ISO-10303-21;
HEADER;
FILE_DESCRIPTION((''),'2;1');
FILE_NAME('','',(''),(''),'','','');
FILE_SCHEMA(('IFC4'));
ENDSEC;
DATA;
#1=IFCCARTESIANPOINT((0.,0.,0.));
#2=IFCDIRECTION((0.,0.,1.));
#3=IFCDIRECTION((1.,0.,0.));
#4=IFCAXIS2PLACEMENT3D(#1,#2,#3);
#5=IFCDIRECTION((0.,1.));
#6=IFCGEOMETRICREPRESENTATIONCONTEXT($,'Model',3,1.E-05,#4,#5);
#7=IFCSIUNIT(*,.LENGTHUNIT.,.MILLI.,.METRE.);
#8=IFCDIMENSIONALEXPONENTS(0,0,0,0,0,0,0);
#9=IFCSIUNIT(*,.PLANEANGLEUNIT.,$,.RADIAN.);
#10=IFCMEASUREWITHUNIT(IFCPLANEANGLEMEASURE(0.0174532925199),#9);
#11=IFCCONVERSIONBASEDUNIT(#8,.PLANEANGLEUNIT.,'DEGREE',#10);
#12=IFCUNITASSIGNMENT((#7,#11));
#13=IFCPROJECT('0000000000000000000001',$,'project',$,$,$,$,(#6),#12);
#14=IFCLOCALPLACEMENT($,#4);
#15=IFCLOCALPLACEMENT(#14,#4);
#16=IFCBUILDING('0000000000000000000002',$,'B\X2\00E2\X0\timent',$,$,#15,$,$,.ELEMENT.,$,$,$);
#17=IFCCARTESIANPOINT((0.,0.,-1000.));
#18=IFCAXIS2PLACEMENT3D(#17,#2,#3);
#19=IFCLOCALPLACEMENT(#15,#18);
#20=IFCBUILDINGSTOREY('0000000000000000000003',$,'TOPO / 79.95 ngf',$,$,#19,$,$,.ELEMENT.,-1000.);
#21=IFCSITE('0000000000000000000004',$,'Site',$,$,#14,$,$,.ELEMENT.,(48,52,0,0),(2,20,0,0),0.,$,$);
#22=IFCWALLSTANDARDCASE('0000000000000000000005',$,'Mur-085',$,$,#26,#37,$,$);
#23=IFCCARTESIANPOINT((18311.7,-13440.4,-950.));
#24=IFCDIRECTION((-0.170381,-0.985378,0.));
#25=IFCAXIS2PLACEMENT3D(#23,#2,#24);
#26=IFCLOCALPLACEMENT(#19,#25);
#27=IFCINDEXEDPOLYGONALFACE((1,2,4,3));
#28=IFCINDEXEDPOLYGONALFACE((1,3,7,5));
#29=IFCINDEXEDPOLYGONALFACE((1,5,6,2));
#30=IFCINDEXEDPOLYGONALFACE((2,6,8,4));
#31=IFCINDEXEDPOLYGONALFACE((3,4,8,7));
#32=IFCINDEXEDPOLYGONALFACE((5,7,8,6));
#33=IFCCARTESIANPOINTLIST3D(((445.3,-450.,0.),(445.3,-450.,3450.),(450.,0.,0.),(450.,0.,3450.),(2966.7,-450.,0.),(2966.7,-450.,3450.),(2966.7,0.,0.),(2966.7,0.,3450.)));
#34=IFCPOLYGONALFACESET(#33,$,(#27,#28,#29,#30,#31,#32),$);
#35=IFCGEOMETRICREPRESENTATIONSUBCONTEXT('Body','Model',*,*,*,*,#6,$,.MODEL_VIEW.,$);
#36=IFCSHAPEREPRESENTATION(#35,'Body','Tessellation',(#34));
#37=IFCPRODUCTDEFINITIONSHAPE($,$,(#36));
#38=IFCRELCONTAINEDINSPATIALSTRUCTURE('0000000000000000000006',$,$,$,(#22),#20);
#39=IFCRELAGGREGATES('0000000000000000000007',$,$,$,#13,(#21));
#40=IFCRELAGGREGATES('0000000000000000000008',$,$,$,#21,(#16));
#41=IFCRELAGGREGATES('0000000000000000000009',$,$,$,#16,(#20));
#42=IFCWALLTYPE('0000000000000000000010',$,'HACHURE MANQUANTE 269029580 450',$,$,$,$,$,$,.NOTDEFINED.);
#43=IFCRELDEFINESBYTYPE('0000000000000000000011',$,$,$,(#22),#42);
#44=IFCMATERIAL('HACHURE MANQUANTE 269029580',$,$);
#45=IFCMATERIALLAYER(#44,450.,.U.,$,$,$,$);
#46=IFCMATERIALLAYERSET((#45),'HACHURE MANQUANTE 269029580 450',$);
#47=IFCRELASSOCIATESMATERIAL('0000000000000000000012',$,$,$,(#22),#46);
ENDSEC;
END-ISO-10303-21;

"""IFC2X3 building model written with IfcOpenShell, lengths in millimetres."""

from ifc_helpers import new_model, entity, si_unit, converted_unit, direction, frame, origin_with_axes, place, context, subcontext, project, spatial, polyline, outline, extrude, material, layer, layer_set, layer_usage, type_object, element, save


model = new_model("IFC2X3")

# Units and contexts
model_context = context("Model", 3, precision=1e-05, world=origin_with_axes(), true_north=direction((0.0, 1.0)))
body_context = subcontext(model_context, "Body", "Model", "MODEL_VIEW")
ifc_project = project(units=[si_unit("LENGTHUNIT", "METRE", prefix="MILLI"), converted_unit("PLANEANGLEUNIT", "DEGREE", entity("IfcPlaneAngleMeasure", 0.0174532925199), si_unit("PLANEANGLEUNIT", "RADIAN"), dimensions=[0, 0, 0, 0, 0, 0, 0])], contexts=[model_context])

# Site, building, storey
site_placement = place(None, origin_with_axes())
site = spatial("IfcSite", under=ifc_project, at=site_placement, Name="Site", CompositionType="ELEMENT", RefLatitude=(48, 52, 0, 0), RefLongitude=(2, 20, 0, 0), RefElevation=0.0)
building_placement = place(site_placement, origin_with_axes())
building = spatial("IfcBuilding", under=site, at=building_placement, Name="Bâtiment", CompositionType="ELEMENT")
storey_placement = place(building_placement, frame((0.0, 0.0, -1000.0), z_axis=(0.0, 0.0, 1.0), x_axis=(1.0, 0.0, 0.0)))
storey = spatial("IfcBuildingStorey", under=building, at=storey_placement, Name="TOPO / 79.95 ngf", CompositionType="ELEMENT", Elevation=-1000.0)

# Wall
ifc_material_1 = material(Name="HACHURE MANQUANTE 269029580")
ifc_layer_1 = layer(ifc_material_1, 450.0, ventilated="UNKNOWN")
ifc_layer_set_1 = layer_set([ifc_layer_1], Name="HACHURE MANQUANTE 269029580 450")
wall_type_1 = type_object("IfcWallType", Name="HACHURE MANQUANTE 269029580 450", PredefinedType="NOTDEFINED")
ifc_layer_usage_1 = layer_usage(ifc_layer_set_1, "AXIS2", "POSITIVE", -450.0)
wall_1_placement = place(storey_placement, frame((18311.7, -13440.4, -950.0), z_axis=(0.0, 0.0, 1.0), x_axis=(-0.170381, -0.985378, 0.0)))
element("IfcWallStandardCase", 1, at=wall_1_placement, inside=storey, type_object=wall_type_1, material=ifc_layer_usage_1, Name="Mur-085", context=body_context, shape_type="SweptSolid", body=[
    extrude(outline(polyline([(445.3, -450.0), (2966.7, -450.0), (2966.7, 0.0), (450.0, 0.0), (445.3, -450.0)])), origin_with_axes(), (0.0, 0.0, 1.0), 3450.0),
])

save(model, "model.ifc")
